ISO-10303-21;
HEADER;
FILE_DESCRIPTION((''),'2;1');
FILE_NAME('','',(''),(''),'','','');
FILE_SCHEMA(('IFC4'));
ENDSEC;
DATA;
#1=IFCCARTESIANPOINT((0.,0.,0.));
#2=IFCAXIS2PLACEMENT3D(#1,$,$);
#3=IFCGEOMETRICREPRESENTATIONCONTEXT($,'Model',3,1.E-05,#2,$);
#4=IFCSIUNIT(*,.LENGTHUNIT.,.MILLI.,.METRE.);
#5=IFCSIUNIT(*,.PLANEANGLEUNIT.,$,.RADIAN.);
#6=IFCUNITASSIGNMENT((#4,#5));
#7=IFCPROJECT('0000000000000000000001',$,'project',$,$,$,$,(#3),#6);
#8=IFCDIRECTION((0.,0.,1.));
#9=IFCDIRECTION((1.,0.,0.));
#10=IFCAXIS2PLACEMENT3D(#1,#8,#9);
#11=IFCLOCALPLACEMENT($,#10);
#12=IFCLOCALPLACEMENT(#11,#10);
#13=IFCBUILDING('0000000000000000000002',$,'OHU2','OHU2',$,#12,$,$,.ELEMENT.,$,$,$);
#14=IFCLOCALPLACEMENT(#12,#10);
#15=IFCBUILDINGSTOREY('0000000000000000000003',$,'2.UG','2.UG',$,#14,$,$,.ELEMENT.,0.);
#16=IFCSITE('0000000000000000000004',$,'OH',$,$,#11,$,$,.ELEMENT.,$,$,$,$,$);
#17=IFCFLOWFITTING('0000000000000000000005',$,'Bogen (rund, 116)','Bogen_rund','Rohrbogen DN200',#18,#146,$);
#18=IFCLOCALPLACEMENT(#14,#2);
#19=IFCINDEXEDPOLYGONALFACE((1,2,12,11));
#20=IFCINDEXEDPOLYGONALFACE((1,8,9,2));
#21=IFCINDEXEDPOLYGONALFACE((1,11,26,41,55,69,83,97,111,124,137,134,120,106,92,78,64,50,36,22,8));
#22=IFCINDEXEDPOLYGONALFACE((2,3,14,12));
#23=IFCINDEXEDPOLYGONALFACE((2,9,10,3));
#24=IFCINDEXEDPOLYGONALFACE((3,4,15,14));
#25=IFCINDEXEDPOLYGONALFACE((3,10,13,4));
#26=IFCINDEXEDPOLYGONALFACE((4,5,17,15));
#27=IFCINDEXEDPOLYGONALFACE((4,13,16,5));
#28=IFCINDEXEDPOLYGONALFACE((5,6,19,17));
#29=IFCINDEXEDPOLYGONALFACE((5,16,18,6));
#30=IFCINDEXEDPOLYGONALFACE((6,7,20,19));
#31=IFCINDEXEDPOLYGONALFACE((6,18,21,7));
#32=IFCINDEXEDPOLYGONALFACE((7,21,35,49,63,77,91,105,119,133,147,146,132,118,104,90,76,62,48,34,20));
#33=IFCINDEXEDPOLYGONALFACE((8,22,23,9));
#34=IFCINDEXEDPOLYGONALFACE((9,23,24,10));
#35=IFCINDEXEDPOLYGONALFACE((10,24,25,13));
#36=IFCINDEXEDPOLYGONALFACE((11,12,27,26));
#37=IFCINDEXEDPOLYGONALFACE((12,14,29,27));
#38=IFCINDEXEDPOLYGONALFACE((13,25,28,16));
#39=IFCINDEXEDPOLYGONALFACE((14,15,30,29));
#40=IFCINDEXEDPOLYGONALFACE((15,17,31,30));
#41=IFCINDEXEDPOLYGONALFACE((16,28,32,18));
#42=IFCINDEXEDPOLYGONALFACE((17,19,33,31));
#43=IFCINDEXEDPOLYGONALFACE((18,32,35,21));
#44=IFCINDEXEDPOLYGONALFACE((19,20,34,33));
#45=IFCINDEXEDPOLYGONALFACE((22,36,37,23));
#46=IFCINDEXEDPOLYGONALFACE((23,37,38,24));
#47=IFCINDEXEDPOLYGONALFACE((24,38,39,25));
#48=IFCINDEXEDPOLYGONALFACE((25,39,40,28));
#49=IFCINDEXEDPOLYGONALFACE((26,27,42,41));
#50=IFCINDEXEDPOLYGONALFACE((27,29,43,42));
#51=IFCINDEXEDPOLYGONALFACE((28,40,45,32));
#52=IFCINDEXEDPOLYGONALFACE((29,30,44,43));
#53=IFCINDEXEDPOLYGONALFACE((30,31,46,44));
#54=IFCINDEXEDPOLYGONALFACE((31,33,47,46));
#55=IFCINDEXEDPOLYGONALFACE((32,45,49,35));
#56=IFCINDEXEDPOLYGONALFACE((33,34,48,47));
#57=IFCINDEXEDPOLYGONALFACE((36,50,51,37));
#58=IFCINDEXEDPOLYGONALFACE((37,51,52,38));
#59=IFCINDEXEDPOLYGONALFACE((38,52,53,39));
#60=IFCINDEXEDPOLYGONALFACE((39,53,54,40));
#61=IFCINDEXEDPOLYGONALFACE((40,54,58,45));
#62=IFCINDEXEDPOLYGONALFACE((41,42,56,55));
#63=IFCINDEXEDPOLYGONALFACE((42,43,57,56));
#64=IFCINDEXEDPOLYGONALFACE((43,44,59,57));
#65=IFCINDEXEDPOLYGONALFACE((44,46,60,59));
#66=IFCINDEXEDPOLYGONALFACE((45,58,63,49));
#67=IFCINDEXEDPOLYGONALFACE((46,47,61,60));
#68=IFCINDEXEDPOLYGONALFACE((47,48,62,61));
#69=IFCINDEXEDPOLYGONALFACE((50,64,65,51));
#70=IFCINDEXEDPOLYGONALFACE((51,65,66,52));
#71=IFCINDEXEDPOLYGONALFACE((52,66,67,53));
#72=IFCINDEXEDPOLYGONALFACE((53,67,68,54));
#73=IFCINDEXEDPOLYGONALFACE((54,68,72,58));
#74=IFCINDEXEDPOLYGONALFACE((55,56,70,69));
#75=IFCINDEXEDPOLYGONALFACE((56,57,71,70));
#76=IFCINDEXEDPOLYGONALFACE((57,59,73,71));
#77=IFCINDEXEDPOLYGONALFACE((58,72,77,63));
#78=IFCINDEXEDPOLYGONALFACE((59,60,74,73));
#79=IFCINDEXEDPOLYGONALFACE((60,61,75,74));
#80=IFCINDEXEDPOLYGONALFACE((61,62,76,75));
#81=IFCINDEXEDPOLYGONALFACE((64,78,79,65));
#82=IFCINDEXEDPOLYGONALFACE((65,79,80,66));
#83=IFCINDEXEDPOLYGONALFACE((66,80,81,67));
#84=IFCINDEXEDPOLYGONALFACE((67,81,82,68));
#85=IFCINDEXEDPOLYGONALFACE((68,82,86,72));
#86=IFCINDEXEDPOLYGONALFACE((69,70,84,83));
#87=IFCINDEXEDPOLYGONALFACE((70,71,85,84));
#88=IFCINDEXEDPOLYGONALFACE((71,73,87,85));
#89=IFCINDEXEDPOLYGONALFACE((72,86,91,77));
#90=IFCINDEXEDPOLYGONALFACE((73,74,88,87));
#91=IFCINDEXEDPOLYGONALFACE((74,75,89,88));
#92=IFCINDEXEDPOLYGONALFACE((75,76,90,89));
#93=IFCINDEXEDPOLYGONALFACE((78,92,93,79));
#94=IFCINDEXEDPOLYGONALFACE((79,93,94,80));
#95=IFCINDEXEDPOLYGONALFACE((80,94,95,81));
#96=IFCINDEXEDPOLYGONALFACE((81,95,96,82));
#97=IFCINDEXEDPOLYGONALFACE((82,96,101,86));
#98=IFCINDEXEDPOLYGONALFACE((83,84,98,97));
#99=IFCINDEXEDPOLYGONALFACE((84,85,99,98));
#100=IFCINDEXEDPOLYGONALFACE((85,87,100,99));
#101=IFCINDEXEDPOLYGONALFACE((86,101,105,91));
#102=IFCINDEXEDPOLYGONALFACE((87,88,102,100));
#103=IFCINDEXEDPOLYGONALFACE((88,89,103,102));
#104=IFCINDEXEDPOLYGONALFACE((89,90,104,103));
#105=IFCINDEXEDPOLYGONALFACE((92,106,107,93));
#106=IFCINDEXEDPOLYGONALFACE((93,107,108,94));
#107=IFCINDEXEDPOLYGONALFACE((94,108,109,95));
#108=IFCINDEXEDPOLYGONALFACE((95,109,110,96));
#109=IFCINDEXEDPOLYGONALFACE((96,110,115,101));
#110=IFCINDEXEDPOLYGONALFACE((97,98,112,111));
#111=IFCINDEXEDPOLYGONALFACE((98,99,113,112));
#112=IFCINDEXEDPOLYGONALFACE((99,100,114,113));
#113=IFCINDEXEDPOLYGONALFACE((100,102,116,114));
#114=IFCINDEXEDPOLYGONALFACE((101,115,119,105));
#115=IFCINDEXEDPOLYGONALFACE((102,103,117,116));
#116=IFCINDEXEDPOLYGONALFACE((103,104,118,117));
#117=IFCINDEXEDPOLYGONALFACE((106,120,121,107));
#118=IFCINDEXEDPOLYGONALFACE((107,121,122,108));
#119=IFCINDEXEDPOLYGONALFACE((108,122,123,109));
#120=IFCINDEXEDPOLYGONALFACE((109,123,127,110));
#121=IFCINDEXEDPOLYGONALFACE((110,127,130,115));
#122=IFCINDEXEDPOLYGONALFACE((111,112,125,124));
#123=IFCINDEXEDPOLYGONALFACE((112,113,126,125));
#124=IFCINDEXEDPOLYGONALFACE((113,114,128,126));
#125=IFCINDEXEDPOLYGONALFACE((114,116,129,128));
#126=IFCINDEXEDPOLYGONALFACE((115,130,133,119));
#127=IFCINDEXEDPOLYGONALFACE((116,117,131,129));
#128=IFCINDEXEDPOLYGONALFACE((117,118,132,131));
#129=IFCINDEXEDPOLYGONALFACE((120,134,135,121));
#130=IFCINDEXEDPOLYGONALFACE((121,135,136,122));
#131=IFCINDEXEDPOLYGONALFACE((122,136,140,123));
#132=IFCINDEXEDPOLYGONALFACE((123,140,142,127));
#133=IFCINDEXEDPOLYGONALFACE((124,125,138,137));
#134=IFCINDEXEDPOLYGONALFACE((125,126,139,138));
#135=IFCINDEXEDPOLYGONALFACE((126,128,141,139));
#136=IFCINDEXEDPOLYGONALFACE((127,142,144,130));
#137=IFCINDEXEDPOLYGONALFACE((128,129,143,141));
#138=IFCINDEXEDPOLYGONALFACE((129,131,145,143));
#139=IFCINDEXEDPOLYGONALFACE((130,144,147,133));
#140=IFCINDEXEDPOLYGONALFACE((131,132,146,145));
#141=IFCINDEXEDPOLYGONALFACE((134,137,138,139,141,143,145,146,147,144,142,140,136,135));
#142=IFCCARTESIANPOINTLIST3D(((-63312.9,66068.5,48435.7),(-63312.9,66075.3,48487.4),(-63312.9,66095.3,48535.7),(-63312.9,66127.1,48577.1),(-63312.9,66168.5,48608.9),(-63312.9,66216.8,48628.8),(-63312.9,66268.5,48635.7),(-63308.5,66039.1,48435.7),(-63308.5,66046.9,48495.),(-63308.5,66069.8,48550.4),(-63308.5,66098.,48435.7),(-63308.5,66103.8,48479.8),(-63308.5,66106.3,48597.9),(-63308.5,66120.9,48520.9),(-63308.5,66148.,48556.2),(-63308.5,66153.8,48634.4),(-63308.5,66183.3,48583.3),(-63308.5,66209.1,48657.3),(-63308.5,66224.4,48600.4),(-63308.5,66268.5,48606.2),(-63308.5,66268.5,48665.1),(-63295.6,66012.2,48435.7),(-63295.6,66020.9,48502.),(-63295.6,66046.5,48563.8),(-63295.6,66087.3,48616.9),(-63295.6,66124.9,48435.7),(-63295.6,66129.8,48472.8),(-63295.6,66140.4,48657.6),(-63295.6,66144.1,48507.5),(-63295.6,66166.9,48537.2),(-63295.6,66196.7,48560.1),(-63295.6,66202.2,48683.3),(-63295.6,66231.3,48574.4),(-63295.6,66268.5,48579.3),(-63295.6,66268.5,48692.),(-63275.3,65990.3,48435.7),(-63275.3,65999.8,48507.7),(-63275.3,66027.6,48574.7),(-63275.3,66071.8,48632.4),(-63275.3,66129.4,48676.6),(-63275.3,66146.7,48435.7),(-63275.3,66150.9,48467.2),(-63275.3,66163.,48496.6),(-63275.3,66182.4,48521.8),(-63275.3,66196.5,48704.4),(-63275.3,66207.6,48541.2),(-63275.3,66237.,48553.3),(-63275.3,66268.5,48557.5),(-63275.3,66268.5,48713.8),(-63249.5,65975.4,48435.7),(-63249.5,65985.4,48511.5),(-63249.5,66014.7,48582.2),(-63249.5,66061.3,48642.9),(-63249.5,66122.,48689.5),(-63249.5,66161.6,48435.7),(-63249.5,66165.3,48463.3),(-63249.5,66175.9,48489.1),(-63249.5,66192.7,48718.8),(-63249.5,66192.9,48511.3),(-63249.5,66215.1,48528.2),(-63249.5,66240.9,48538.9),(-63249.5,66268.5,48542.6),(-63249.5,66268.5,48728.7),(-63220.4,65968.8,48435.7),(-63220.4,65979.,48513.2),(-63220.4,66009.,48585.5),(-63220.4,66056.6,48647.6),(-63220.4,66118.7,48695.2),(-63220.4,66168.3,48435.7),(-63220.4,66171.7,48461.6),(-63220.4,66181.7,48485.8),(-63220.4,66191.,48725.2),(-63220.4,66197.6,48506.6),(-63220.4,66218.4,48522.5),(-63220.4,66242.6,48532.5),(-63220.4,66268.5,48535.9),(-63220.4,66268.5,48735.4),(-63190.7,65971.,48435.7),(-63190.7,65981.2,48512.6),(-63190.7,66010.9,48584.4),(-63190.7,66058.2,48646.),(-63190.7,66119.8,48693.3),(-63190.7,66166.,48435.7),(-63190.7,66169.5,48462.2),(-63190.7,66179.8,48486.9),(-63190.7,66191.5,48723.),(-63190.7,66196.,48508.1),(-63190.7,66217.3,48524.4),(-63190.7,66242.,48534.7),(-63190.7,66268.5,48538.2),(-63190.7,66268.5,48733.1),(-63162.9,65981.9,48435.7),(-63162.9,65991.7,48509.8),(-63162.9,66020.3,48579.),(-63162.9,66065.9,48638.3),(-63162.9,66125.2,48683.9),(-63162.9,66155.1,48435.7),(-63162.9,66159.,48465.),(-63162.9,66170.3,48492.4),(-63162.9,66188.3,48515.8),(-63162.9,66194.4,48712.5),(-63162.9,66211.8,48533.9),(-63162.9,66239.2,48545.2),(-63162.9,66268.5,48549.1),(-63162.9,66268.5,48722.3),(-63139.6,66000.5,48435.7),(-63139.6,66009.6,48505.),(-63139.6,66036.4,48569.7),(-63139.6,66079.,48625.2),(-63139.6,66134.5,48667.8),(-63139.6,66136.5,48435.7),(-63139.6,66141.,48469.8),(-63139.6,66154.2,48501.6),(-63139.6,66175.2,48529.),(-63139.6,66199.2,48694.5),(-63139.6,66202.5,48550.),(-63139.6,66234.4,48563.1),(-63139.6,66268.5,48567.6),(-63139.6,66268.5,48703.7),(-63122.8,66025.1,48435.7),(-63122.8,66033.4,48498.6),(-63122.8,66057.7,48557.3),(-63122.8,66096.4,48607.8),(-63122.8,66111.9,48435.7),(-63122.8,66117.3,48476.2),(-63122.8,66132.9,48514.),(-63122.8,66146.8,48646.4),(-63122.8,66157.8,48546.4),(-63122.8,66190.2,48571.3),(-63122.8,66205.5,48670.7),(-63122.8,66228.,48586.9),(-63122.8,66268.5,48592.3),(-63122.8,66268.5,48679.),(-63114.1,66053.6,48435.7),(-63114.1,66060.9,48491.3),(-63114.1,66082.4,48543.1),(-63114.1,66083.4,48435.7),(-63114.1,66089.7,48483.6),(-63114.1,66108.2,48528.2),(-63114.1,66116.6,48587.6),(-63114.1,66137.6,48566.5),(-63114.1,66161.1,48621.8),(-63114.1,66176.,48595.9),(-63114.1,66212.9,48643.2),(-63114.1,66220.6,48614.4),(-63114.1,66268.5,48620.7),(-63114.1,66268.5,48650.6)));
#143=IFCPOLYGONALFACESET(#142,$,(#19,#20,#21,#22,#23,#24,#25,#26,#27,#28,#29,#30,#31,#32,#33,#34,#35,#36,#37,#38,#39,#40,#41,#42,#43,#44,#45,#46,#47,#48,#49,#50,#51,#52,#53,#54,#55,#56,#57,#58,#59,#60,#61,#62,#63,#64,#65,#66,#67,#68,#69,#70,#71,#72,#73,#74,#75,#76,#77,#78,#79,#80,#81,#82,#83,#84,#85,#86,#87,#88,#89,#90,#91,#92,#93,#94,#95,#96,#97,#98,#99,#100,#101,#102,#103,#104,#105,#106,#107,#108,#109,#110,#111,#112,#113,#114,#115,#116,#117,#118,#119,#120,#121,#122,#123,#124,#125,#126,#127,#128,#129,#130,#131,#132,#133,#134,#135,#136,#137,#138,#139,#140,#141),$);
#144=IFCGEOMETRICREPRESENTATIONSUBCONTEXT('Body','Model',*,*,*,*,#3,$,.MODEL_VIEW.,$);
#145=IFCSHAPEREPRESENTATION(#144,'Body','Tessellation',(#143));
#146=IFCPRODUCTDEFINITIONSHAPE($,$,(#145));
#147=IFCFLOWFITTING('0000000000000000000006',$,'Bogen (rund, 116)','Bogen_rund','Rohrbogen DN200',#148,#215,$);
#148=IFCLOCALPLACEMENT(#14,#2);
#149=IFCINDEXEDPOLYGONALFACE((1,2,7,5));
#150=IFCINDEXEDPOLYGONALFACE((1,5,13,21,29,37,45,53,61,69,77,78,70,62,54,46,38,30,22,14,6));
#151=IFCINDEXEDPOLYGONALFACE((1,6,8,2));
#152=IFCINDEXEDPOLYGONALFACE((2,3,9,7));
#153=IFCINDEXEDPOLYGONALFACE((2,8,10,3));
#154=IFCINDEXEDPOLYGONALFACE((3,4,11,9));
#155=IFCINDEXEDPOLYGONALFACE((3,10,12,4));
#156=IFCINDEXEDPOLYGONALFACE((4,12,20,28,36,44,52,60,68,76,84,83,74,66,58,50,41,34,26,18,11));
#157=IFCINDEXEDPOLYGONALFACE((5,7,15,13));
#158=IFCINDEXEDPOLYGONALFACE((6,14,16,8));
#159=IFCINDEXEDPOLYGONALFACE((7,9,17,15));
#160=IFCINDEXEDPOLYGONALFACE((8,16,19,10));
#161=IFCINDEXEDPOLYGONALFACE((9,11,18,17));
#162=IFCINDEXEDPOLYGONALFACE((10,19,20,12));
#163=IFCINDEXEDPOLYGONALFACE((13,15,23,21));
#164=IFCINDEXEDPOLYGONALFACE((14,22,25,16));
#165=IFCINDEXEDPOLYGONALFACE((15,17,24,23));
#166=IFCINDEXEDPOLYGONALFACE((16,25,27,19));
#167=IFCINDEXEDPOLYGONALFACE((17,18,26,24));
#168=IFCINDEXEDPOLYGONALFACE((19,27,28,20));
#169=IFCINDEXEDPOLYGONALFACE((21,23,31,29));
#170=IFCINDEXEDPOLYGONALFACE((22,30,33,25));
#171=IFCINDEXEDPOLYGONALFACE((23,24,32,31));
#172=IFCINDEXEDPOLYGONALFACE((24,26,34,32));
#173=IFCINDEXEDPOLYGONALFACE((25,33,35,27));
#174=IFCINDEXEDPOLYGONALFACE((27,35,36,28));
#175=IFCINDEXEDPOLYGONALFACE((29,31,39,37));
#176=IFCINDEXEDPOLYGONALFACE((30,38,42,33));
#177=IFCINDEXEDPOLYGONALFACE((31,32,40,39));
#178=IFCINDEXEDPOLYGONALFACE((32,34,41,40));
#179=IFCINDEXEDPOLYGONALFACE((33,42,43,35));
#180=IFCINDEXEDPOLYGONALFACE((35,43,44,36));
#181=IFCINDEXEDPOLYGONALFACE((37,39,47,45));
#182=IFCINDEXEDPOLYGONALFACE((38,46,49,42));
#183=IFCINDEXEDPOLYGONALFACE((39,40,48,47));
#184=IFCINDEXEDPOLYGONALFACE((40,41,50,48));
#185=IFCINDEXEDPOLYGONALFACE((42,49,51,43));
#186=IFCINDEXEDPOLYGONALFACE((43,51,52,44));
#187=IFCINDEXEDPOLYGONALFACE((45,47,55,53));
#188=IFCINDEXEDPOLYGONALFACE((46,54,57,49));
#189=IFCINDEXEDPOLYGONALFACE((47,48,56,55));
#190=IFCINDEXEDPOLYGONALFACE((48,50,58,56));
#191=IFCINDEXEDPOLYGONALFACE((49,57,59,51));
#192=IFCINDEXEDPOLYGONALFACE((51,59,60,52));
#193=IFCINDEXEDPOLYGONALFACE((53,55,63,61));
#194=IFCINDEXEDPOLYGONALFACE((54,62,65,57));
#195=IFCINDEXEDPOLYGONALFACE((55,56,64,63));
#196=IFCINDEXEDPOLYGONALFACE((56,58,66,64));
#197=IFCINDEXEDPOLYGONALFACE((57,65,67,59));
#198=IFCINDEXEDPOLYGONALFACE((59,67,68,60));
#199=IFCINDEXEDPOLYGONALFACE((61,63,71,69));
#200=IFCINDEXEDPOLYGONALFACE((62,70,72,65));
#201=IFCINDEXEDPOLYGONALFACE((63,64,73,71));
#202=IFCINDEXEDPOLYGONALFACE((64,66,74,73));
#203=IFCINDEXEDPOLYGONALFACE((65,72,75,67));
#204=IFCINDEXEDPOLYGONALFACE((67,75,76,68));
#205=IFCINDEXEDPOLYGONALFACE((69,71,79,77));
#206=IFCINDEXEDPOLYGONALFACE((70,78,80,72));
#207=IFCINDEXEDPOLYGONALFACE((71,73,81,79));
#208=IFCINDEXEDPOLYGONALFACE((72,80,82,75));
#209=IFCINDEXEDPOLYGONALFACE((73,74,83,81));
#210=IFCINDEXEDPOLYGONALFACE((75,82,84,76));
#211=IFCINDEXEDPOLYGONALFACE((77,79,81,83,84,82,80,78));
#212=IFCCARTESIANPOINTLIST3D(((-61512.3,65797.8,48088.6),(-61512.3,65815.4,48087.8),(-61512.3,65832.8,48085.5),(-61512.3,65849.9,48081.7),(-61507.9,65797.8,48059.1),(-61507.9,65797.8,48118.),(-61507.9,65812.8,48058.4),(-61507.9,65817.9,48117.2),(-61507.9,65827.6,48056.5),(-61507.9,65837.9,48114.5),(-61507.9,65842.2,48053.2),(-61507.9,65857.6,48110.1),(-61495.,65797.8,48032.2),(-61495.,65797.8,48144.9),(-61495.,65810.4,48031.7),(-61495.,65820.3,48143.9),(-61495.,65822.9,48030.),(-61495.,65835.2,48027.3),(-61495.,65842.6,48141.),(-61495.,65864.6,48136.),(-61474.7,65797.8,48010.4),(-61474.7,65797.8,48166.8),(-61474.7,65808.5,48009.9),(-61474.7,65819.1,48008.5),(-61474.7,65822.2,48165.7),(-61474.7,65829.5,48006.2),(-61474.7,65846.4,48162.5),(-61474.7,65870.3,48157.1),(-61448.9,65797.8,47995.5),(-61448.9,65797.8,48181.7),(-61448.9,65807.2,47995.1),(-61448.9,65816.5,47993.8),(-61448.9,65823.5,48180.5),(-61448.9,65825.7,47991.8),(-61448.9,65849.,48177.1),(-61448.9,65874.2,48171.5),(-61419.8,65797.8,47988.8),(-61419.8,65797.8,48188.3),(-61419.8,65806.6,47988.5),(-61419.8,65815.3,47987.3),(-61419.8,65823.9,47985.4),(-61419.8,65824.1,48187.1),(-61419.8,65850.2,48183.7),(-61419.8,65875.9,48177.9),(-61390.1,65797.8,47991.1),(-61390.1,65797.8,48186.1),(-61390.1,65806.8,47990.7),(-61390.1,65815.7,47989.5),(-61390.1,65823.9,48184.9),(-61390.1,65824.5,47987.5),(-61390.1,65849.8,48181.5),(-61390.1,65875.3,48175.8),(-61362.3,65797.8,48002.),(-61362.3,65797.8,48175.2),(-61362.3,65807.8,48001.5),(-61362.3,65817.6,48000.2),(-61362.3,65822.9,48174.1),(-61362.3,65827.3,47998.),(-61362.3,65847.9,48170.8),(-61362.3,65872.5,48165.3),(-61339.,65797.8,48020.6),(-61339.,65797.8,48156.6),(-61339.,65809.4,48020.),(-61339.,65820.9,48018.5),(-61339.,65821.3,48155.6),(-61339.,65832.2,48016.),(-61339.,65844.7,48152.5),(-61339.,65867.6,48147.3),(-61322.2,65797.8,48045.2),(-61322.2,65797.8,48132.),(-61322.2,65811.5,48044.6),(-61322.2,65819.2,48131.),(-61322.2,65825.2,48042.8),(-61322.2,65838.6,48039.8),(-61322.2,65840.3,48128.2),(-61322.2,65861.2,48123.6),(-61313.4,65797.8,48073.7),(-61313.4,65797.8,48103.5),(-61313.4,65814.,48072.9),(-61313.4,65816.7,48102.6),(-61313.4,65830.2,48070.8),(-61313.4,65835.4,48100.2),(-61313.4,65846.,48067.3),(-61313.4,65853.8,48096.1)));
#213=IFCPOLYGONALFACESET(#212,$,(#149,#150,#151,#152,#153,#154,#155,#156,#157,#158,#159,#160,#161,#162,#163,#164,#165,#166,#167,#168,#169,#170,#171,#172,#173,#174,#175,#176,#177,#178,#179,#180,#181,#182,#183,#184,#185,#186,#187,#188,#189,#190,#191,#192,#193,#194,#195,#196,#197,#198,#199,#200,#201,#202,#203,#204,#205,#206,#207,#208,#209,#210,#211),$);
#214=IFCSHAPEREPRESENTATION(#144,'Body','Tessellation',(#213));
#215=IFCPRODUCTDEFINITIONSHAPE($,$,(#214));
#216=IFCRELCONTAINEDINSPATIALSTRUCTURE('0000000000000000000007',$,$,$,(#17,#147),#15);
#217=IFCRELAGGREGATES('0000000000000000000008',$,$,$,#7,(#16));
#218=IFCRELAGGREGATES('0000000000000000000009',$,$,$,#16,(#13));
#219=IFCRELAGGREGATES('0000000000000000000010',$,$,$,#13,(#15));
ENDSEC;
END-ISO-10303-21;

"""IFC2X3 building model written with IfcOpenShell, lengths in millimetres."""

from ifc_helpers import new_model, entity, si_unit, frame, origin, origin_with_axes, place, context, subcontext, project, spatial, element, save


model = new_model("IFC2X3")

# Units and contexts
model_context = context("Model", 3, precision=1e-05, world=origin())
body_context = subcontext(model_context, "Body", "Model", "MODEL_VIEW")
ifc_project = project(units=[si_unit("LENGTHUNIT", "METRE", prefix="MILLI"), si_unit("PLANEANGLEUNIT", "RADIAN")], contexts=[model_context])

# Site, building, storey
site_placement = place(None, origin_with_axes())
site = spatial("IfcSite", under=ifc_project, at=site_placement, Name="OH", CompositionType="ELEMENT")
building_placement = place(site_placement, origin_with_axes())
building = spatial("IfcBuilding", under=site, at=building_placement, Name="OHU2", Description="OHU2", CompositionType="ELEMENT")
storey_placement = place(building_placement, origin_with_axes())
storey = spatial("IfcBuildingStorey", under=building, at=storey_placement, Name="2.UG", Description="2.UG", CompositionType="ELEMENT", Elevation=0.0)

# Flow fittings
flow_fitting_1_placement = place(storey_placement, frame((-63212.9, 66118.5, 48585.7), z_axis=(0.0, 0.0, 1.0), x_axis=(1.0, 0.0, 0.0)))
element("IfcFlowFitting", 1, at=flow_fitting_1_placement, inside=storey, Name="Bogen (rund, 116)", Description="Bogen_rund", ObjectType="Rohrbogen DN200", context=body_context, shape_type="SweptSolid", body=[
    entity("IfcRevolvedAreaSolid", entity("IfcCircleProfileDef", "AREA", None, entity("IfcAxis2Placement2D", entity("IfcCartesianPoint", [0.0, 0.0]), entity("IfcDirection", [1.0, 0.0])), 100.0), entity("IfcAxis2Placement3D", entity("IfcCartesianPoint", [0.0, 150.0, 50.0]), entity("IfcDirection", [0.000006, -1.0, -0.000006]), entity("IfcDirection", [-1.0, -0.000006, 0.000019])), entity("IfcAxis1Placement", entity("IfcCartesianPoint", [0.0, 200.0, 0.0]), entity("IfcDirection", [-1.0, 0.0, 0.0])), 1.570796),
])
flow_fitting_2_placement = place(storey_placement, frame((-61412.3, 65818.0, 48088.9), z_axis=(0.0, 0.0, 1.0), x_axis=(1.0, 0.0, 0.0)))
element("IfcFlowFitting", 2, at=flow_fitting_2_placement, inside=storey, Name="Bogen (rund, 116)", Description="Bogen_rund", ObjectType="Rohrbogen DN200", context=body_context, shape_type="SweptSolid", body=[
    entity("IfcRevolvedAreaSolid", entity("IfcCircleProfileDef", "AREA", None, entity("IfcAxis2Placement2D", entity("IfcCartesianPoint", [0.0, 0.0]), entity("IfcDirection", [1.0, 0.0])), 100.0), entity("IfcAxis2Placement3D", entity("IfcCartesianPoint", [0.0, 31.9, -7.3]), entity("IfcDirection", [0.0, -0.965475, 0.260497]), entity("IfcDirection", [-1.0, 0.0, 0.0])), entity("IfcAxis1Placement", entity("IfcCartesianPoint", [0.0, 200.0, 0.0]), entity("IfcDirection", [-1.0, 0.0, 0.0])), 0.263545),
])

save(model, "model.ifc")
